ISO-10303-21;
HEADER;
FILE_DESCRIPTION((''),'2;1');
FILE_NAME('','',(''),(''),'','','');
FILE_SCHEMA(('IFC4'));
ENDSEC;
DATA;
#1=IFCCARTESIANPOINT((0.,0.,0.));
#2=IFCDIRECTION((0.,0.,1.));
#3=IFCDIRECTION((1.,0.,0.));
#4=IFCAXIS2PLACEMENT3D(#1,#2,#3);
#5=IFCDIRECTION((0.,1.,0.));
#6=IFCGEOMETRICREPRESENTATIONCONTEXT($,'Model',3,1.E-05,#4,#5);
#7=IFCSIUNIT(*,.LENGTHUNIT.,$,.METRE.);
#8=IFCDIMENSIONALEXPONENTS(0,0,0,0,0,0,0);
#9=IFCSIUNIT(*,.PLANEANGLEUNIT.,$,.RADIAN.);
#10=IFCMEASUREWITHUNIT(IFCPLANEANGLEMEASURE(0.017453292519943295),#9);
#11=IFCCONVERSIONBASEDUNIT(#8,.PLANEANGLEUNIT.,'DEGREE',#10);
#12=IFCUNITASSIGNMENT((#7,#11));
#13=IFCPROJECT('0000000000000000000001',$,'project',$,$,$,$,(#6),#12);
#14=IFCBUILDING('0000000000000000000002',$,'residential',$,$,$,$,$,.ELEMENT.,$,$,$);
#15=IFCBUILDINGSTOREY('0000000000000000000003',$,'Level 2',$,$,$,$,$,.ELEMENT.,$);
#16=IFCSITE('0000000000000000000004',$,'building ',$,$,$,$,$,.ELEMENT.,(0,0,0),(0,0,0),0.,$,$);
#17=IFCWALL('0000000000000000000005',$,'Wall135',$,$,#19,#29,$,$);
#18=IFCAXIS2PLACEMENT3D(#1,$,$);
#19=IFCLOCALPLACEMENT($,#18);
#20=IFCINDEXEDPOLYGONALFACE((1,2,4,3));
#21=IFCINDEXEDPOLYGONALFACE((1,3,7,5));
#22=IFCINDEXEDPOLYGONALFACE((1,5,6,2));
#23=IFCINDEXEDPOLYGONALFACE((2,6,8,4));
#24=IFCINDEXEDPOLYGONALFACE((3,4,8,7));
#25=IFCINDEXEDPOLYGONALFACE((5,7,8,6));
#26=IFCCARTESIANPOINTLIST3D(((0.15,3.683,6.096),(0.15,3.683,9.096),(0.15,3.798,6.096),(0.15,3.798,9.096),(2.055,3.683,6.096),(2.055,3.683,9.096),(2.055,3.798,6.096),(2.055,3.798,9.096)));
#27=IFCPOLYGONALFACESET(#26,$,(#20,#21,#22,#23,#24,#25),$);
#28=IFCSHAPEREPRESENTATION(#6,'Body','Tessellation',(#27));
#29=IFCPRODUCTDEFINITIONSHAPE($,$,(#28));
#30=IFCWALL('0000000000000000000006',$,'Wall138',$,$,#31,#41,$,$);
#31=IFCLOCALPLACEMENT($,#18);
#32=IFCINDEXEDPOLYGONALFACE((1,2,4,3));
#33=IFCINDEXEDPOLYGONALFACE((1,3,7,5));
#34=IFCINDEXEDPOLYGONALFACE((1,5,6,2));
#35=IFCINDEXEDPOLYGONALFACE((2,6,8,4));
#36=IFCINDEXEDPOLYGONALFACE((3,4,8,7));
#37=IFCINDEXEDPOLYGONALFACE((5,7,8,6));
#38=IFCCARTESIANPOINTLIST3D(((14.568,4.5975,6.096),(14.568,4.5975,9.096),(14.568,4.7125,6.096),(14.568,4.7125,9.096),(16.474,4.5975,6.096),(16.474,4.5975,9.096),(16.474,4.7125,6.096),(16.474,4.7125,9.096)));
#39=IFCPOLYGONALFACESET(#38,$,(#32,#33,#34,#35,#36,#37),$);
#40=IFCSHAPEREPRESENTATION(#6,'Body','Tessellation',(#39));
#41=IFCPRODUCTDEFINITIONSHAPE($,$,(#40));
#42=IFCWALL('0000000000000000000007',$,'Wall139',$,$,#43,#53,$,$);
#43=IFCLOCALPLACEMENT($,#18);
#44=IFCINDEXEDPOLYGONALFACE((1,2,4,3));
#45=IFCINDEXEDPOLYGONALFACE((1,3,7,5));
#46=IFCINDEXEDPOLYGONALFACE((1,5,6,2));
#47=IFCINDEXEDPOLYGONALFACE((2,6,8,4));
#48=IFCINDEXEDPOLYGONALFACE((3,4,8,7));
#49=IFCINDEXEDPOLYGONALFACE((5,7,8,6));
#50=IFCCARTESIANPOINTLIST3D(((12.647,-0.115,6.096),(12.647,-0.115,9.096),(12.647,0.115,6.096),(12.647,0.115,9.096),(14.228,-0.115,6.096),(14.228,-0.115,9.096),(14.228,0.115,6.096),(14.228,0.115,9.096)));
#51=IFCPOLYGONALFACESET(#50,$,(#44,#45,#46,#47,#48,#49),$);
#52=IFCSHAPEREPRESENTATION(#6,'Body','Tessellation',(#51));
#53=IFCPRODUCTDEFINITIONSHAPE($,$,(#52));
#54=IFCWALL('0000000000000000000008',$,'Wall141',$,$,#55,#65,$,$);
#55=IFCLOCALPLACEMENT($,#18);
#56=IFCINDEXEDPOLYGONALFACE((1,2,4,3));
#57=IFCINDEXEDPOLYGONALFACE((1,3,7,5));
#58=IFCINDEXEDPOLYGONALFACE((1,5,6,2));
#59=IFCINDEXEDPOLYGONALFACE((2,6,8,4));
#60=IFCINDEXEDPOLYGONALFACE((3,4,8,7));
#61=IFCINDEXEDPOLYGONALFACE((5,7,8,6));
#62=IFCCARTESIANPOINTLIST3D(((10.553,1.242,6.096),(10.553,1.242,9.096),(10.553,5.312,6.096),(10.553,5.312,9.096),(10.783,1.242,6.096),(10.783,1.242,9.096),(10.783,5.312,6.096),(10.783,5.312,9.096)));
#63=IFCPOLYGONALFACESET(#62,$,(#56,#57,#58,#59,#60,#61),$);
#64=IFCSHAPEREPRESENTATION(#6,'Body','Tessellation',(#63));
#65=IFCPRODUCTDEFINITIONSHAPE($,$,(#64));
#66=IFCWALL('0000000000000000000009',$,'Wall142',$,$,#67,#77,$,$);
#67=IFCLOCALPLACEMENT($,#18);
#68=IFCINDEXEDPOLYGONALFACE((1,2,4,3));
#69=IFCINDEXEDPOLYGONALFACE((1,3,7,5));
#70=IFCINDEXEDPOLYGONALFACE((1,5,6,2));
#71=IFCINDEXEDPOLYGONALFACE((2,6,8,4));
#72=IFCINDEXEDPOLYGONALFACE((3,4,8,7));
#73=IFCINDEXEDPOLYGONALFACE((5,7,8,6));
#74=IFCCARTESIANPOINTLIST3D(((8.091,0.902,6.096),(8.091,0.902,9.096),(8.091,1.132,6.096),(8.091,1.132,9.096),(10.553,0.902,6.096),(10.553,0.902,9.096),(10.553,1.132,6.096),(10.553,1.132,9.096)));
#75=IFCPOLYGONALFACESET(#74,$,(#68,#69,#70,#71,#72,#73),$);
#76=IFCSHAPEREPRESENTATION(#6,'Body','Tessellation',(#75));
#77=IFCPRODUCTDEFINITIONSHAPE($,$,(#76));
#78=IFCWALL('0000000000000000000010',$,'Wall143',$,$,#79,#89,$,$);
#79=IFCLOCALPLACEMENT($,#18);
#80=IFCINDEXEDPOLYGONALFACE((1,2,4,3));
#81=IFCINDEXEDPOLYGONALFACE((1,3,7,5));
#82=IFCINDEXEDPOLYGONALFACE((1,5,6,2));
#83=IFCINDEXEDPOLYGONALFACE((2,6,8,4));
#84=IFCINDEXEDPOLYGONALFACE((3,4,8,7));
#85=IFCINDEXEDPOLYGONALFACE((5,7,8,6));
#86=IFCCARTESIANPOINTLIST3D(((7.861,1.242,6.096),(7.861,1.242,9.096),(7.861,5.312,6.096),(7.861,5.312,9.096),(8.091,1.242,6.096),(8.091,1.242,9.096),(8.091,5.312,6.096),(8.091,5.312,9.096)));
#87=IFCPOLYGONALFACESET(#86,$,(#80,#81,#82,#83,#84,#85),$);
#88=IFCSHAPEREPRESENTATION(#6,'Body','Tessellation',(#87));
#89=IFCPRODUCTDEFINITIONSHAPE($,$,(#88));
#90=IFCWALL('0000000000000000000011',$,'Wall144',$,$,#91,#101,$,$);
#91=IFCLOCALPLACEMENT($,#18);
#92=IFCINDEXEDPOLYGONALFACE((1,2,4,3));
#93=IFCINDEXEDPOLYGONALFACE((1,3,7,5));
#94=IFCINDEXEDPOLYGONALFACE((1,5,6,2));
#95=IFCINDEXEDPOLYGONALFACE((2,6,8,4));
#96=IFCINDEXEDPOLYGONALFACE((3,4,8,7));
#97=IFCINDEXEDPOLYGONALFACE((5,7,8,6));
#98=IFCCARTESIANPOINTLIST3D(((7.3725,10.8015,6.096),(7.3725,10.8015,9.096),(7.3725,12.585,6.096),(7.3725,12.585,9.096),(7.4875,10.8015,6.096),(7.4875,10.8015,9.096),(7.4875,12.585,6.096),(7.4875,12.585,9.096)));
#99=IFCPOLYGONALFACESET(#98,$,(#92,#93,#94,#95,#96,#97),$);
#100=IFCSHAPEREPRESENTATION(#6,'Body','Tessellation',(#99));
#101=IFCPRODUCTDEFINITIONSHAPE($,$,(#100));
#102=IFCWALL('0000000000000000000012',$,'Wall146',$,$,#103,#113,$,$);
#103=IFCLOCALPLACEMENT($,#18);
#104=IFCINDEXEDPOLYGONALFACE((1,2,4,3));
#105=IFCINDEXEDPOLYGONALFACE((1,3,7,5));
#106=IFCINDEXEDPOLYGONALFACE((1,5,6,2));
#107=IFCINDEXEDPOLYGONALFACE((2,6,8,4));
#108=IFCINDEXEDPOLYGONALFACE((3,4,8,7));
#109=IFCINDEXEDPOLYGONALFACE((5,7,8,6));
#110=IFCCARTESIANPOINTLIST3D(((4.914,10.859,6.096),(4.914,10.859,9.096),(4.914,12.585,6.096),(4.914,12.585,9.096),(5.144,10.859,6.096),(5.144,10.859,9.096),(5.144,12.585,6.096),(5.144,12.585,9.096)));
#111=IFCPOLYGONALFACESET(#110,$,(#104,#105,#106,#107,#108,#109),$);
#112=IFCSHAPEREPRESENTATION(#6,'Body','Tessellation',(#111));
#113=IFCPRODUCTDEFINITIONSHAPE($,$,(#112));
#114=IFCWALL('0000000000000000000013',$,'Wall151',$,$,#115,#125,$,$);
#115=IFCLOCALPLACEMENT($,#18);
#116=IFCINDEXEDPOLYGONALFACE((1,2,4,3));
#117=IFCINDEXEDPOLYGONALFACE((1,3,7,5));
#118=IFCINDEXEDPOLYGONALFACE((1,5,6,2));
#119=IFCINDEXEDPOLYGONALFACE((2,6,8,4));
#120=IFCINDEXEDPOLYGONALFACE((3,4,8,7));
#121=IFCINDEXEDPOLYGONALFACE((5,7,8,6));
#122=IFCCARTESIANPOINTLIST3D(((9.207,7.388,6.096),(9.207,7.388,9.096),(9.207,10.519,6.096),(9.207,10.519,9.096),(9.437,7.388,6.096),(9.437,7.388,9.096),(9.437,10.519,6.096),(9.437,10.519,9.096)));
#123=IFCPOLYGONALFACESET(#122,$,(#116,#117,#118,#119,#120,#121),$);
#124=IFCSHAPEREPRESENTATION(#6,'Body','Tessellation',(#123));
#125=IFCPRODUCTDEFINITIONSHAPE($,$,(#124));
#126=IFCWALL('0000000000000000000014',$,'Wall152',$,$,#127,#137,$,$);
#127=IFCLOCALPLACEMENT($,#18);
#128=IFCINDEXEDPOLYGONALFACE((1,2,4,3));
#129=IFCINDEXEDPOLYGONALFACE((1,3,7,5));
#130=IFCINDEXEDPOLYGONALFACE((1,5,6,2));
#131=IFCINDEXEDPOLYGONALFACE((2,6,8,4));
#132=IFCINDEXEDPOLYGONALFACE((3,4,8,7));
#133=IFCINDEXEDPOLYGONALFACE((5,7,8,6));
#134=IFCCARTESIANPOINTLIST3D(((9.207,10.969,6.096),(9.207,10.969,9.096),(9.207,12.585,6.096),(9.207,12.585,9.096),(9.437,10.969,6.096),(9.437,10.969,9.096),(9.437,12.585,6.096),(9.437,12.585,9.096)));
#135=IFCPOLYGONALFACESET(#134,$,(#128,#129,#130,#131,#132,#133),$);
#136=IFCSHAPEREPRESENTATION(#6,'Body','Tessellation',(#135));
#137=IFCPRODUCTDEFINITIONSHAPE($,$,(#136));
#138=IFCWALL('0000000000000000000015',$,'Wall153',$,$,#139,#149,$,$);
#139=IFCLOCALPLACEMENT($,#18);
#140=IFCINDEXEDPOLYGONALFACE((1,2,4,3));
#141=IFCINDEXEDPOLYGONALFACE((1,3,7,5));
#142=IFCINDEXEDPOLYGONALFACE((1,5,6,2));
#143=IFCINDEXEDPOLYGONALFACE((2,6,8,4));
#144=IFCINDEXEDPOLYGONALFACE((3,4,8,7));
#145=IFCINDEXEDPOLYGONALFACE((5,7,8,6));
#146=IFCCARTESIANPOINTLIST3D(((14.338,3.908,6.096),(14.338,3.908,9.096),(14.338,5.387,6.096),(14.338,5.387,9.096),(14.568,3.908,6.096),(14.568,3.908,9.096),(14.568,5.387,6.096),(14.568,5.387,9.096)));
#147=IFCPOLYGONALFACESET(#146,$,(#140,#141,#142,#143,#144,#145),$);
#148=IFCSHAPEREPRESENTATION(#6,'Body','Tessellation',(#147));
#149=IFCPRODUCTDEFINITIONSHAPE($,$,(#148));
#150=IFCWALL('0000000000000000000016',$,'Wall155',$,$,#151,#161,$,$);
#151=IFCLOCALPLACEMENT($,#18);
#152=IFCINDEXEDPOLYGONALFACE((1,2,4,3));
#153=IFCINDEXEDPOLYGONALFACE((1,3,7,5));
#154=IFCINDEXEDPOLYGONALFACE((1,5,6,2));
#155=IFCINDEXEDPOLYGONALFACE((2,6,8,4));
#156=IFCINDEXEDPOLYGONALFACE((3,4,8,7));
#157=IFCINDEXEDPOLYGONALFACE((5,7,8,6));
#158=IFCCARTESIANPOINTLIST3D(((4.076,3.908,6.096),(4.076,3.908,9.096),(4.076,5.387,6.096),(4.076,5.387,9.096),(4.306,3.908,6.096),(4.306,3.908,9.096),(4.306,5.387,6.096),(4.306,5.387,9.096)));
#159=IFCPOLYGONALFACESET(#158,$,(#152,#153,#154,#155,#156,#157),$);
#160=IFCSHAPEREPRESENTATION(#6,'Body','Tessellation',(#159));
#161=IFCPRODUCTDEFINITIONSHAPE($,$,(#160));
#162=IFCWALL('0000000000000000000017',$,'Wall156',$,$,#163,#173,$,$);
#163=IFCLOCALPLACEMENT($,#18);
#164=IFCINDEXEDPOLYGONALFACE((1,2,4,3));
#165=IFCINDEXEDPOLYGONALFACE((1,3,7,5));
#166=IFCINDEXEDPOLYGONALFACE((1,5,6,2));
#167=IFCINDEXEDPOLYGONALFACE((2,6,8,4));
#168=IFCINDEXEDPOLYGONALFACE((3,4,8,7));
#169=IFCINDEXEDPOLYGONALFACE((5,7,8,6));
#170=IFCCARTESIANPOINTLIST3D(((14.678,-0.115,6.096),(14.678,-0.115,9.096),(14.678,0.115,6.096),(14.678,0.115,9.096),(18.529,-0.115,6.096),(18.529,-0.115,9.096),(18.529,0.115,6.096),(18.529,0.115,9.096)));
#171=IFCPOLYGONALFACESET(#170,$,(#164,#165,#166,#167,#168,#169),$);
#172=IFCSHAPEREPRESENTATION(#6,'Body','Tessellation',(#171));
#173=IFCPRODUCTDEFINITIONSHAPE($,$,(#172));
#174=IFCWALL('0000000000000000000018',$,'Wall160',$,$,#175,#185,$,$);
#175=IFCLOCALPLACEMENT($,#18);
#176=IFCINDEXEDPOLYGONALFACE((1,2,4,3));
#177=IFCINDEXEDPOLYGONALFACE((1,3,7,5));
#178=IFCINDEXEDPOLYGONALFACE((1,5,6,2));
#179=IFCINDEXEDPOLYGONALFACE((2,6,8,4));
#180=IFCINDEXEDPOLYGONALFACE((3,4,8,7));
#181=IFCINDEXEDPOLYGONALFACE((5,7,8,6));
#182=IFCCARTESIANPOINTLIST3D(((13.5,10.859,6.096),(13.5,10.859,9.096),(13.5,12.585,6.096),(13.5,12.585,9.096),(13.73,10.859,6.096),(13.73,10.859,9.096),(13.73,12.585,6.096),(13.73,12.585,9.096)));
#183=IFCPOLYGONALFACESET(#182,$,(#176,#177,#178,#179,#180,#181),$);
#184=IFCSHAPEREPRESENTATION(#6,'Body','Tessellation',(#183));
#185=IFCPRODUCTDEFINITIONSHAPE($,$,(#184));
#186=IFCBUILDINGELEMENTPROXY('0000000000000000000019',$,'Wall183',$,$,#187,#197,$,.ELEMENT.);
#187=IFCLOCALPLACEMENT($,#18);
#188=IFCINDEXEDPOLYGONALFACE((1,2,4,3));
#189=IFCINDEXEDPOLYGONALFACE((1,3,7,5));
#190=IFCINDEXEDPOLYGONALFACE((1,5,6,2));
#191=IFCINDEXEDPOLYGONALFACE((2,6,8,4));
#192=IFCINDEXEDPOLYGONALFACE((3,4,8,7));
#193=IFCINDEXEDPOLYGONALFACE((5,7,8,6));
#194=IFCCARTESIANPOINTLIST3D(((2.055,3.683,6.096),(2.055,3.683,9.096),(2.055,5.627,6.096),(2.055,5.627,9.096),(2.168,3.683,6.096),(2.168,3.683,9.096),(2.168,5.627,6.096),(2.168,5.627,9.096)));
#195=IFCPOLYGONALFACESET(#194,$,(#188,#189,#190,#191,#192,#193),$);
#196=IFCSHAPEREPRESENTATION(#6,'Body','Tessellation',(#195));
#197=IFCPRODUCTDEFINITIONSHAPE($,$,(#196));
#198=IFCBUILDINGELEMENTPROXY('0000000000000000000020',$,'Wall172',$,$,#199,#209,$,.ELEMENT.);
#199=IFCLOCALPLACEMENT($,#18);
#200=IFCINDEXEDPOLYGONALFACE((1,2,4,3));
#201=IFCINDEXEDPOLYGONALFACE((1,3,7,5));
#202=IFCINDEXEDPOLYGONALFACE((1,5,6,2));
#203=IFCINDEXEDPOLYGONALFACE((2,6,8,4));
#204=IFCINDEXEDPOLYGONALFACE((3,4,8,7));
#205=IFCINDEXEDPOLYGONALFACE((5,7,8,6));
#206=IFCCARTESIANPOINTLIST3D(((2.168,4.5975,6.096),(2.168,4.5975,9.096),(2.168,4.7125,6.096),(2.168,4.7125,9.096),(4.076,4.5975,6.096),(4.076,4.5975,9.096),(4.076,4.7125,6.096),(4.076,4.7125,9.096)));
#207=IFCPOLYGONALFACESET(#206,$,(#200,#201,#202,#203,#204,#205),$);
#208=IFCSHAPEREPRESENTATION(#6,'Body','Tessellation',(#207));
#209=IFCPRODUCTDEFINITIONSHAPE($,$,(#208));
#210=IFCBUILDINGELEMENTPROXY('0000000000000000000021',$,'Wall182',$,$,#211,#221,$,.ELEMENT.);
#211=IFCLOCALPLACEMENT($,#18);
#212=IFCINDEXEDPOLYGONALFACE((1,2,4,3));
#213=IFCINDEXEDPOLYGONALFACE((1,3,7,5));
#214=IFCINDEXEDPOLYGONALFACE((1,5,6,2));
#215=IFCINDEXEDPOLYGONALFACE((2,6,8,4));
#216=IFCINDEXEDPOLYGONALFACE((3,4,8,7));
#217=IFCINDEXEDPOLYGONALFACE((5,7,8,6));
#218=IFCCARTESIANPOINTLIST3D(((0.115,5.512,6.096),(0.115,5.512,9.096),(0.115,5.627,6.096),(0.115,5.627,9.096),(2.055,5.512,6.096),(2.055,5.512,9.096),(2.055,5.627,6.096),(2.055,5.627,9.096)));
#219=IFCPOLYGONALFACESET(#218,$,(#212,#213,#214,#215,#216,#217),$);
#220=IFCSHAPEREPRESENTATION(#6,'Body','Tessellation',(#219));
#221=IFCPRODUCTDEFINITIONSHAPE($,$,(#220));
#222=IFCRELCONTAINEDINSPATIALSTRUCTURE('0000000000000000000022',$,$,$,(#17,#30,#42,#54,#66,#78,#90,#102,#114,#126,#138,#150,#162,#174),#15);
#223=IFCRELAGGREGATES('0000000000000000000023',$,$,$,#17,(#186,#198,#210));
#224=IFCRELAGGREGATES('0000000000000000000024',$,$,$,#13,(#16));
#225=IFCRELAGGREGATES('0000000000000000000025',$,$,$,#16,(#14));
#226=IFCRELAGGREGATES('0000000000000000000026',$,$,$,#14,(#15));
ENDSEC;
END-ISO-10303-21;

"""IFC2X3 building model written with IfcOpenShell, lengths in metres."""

from ifc_helpers import new_model, entity, si_unit, converted_unit, direction, frame, frame_2d, origin_with_axes, place, context, project, spatial, rectangle, extrude, element, aggregate, save


model = new_model("IFC2X3")

# Units and contexts
model_context = context("Model", 3, precision=1e-05, world=origin_with_axes(), true_north=direction((0.0, 1.0, 0.0)))
ifc_project = project(units=[si_unit("LENGTHUNIT", "METRE"), converted_unit("PLANEANGLEUNIT", "DEGREE", entity("IfcPlaneAngleMeasure", 0.017453292519943295), si_unit("PLANEANGLEUNIT", "RADIAN"), dimensions=[0, 0, 0, 0, 0, 0, 0])], contexts=[model_context])

# Site, building, storey
site = spatial("IfcSite", under=ifc_project, Name="building ", CompositionType="ELEMENT", RefLatitude=(0, 0, 0), RefLongitude=(0, 0, 0), RefElevation=0.0)
building = spatial("IfcBuilding", under=site, Name="residential", CompositionType="ELEMENT")
storey = spatial("IfcBuildingStorey", under=building, Name="Level 2", CompositionType="ELEMENT")

# Shared definitions
placement = place(None, origin_with_axes())

# Wall
wall_1 = element("IfcWall", 1, at=placement, inside=storey, Name="Wall135", context=model_context, shape_type="SweptSolid", body=[
    extrude(rectangle(XDim=1.905, YDim=0.115, at=frame_2d((0.0, 0.0), x_axis=(1.0, 0.0, 0.0))), frame((1.1025, 3.7405, 6.096), z_axis=(0.0, 0.0, 1.0), x_axis=(1.0, 0.0, 0.0)), (0.0, 0.0, 1.0), 3.0),
])

# Walls
element("IfcWall", 2, at=placement, inside=storey, Name="Wall138", context=model_context, shape_type="SweptSolid", body=[
    extrude(rectangle(XDim=1.906, YDim=0.115, at=frame_2d((0.0, 0.0), x_axis=(-1.0, 0.0, 0.0))), frame((15.521, 4.655, 6.096), z_axis=(0.0, 0.0, 1.0), x_axis=(1.0, 0.0, 0.0)), (0.0, 0.0, 1.0), 3.0),
])
element("IfcWall", 3, at=placement, inside=storey, Name="Wall139", context=model_context, shape_type="SweptSolid", body=[
    extrude(rectangle(XDim=1.581, YDim=0.23, at=frame_2d((0.0, 0.0), x_axis=(-1.0, 0.0, 0.0))), frame((13.4375, 0.0, 6.096), z_axis=(0.0, 0.0, 1.0), x_axis=(1.0, 0.0, 0.0)), (0.0, 0.0, 1.0), 3.0),
])
element("IfcWall", 4, at=placement, inside=storey, Name="Wall141", context=model_context, shape_type="SweptSolid", body=[
    extrude(rectangle(XDim=4.07, YDim=0.23, at=frame_2d((0.0, 0.0), x_axis=(0.0, -1.0, 0.0))), frame((10.668, 3.277, 6.096), z_axis=(0.0, 0.0, 1.0), x_axis=(1.0, 0.0, 0.0)), (0.0, 0.0, 1.0), 3.0),
])
element("IfcWall", 5, at=placement, inside=storey, Name="Wall142", context=model_context, shape_type="SweptSolid", body=[
    extrude(rectangle(XDim=2.462, YDim=0.23, at=frame_2d((0.0, 0.0), x_axis=(1.0, 0.0, 0.0))), frame((9.322, 1.017, 6.096), z_axis=(0.0, 0.0, 1.0), x_axis=(1.0, 0.0, 0.0)), (0.0, 0.0, 1.0), 3.0),
])
element("IfcWall", 6, at=placement, inside=storey, Name="Wall143", context=model_context, shape_type="SweptSolid", body=[
    extrude(rectangle(XDim=4.07, YDim=0.23, at=frame_2d((0.0, 0.0), x_axis=(0.0, -1.0, 0.0))), frame((7.976, 3.277, 6.096), z_axis=(0.0, 0.0, 1.0), x_axis=(1.0, 0.0, 0.0)), (0.0, 0.0, 1.0), 3.0),
])
element("IfcWall", 7, at=placement, inside=storey, Name="Wall144", context=model_context, shape_type="SweptSolid", body=[
    extrude(rectangle(XDim=1.7835, YDim=0.115, at=frame_2d((0.0, 0.0), x_axis=(0.0, -1.0, 0.0))), frame((7.43, 11.6933, 6.096), z_axis=(0.0, 0.0, 1.0), x_axis=(1.0, 0.0, 0.0)), (0.0, 0.0, 1.0), 3.0),
])
element("IfcWall", 8, at=placement, inside=storey, Name="Wall146", context=model_context, shape_type="SweptSolid", body=[
    extrude(rectangle(XDim=1.726, YDim=0.23, at=frame_2d((0.0, 0.0), x_axis=(0.0, 1.0, 0.0))), frame((5.029, 11.722, 6.096), z_axis=(0.0, 0.0, 1.0), x_axis=(1.0, 0.0, 0.0)), (0.0, 0.0, 1.0), 3.0),
])
element("IfcWall", 9, at=placement, inside=storey, Name="Wall151", context=model_context, shape_type="SweptSolid", body=[
    extrude(rectangle(XDim=3.131, YDim=0.23, at=frame_2d((0.0, 0.0), x_axis=(0.0, -1.0, 0.0))), frame((9.322, 8.9535, 6.096), z_axis=(0.0, 0.0, 1.0), x_axis=(1.0, 0.0, 0.0)), (0.0, 0.0, 1.0), 3.0),
])
element("IfcWall", 10, at=placement, inside=storey, Name="Wall152", context=model_context, shape_type="SweptSolid", body=[
    extrude(rectangle(XDim=1.616, YDim=0.23, at=frame_2d((0.0, 0.0), x_axis=(0.0, -1.0, 0.0))), frame((9.322, 11.777, 6.096), z_axis=(0.0, 0.0, 1.0), x_axis=(1.0, 0.0, 0.0)), (0.0, 0.0, 1.0), 3.0),
])
element("IfcWall", 11, at=placement, inside=storey, Name="Wall153", context=model_context, shape_type="SweptSolid", body=[
    extrude(rectangle(XDim=1.479, YDim=0.23, at=frame_2d((0.0, 0.0), x_axis=(0.0, 1.0, 0.0))), frame((14.453, 4.6475, 6.096), z_axis=(0.0, 0.0, 1.0), x_axis=(1.0, 0.0, 0.0)), (0.0, 0.0, 1.0), 3.0),
])
element("IfcWall", 12, at=placement, inside=storey, Name="Wall155", context=model_context, shape_type="SweptSolid", body=[
    extrude(rectangle(XDim=1.479, YDim=0.23, at=frame_2d((0.0, 0.0), x_axis=(0.0, -1.0, 0.0))), frame((4.191, 4.6475, 6.096), z_axis=(0.0, 0.0, 1.0), x_axis=(1.0, 0.0, 0.0)), (0.0, 0.0, 1.0), 3.0),
])
element("IfcWall", 13, at=placement, inside=storey, Name="Wall156", context=model_context, shape_type="SweptSolid", body=[
    extrude(rectangle(XDim=3.851, YDim=0.23, at=frame_2d((0.0, 0.0), x_axis=(1.0, 0.0, 0.0))), frame((16.6035, 0.0, 6.096), z_axis=(0.0, 0.0, 1.0), x_axis=(1.0, 0.0, 0.0)), (0.0, 0.0, 1.0), 3.0),
])
element("IfcWall", 14, at=placement, inside=storey, Name="Wall160", context=model_context, shape_type="SweptSolid", body=[
    extrude(rectangle(XDim=1.726, YDim=0.23, at=frame_2d((0.0, 0.0), x_axis=(0.0, -1.0, 0.0))), frame((13.615, 11.722, 6.096), z_axis=(0.0, 0.0, 1.0), x_axis=(1.0, 0.0, 0.0)), (0.0, 0.0, 1.0), 3.0),
])

# Building element proxies
proxy_1 = element("IfcBuildingElementProxy", 15, at=placement, Name="Wall183", CompositionType="ELEMENT", context=model_context, shape_type="SweptSolid", body=[
    extrude(rectangle(XDim=1.944, YDim=0.113, at=frame_2d((0.0, 0.0), x_axis=(0.0, 1.0, 0.0))), frame((2.1115, 4.655, 6.096), z_axis=(0.0, 0.0, 1.0), x_axis=(1.0, 0.0, 0.0)), (0.0, 0.0, 1.0), 3.0),
])
proxy_2 = element("IfcBuildingElementProxy", 16, at=placement, Name="Wall172", CompositionType="ELEMENT", context=model_context, shape_type="SweptSolid", body=[
    extrude(rectangle(XDim=1.908, YDim=0.115, at=frame_2d((0.0, 0.0), x_axis=(1.0, 0.0, 0.0))), frame((3.122, 4.655, 6.096), z_axis=(0.0, 0.0, 1.0), x_axis=(1.0, 0.0, 0.0)), (0.0, 0.0, 1.0), 3.0),
])
proxy_3 = element("IfcBuildingElementProxy", 17, at=placement, Name="Wall182", CompositionType="ELEMENT", context=model_context, shape_type="SweptSolid", body=[
    extrude(rectangle(XDim=1.94, YDim=0.115, at=frame_2d((0.0, 0.0), x_axis=(-1.0, 0.0, 0.0))), frame((1.085, 5.5695, 6.096), z_axis=(0.0, 0.0, 1.0), x_axis=(1.0, 0.0, 0.0)), (0.0, 0.0, 1.0), 3.0),
])
aggregate(wall_1, [proxy_1, proxy_2, proxy_3])

save(model, "model.ifc")
